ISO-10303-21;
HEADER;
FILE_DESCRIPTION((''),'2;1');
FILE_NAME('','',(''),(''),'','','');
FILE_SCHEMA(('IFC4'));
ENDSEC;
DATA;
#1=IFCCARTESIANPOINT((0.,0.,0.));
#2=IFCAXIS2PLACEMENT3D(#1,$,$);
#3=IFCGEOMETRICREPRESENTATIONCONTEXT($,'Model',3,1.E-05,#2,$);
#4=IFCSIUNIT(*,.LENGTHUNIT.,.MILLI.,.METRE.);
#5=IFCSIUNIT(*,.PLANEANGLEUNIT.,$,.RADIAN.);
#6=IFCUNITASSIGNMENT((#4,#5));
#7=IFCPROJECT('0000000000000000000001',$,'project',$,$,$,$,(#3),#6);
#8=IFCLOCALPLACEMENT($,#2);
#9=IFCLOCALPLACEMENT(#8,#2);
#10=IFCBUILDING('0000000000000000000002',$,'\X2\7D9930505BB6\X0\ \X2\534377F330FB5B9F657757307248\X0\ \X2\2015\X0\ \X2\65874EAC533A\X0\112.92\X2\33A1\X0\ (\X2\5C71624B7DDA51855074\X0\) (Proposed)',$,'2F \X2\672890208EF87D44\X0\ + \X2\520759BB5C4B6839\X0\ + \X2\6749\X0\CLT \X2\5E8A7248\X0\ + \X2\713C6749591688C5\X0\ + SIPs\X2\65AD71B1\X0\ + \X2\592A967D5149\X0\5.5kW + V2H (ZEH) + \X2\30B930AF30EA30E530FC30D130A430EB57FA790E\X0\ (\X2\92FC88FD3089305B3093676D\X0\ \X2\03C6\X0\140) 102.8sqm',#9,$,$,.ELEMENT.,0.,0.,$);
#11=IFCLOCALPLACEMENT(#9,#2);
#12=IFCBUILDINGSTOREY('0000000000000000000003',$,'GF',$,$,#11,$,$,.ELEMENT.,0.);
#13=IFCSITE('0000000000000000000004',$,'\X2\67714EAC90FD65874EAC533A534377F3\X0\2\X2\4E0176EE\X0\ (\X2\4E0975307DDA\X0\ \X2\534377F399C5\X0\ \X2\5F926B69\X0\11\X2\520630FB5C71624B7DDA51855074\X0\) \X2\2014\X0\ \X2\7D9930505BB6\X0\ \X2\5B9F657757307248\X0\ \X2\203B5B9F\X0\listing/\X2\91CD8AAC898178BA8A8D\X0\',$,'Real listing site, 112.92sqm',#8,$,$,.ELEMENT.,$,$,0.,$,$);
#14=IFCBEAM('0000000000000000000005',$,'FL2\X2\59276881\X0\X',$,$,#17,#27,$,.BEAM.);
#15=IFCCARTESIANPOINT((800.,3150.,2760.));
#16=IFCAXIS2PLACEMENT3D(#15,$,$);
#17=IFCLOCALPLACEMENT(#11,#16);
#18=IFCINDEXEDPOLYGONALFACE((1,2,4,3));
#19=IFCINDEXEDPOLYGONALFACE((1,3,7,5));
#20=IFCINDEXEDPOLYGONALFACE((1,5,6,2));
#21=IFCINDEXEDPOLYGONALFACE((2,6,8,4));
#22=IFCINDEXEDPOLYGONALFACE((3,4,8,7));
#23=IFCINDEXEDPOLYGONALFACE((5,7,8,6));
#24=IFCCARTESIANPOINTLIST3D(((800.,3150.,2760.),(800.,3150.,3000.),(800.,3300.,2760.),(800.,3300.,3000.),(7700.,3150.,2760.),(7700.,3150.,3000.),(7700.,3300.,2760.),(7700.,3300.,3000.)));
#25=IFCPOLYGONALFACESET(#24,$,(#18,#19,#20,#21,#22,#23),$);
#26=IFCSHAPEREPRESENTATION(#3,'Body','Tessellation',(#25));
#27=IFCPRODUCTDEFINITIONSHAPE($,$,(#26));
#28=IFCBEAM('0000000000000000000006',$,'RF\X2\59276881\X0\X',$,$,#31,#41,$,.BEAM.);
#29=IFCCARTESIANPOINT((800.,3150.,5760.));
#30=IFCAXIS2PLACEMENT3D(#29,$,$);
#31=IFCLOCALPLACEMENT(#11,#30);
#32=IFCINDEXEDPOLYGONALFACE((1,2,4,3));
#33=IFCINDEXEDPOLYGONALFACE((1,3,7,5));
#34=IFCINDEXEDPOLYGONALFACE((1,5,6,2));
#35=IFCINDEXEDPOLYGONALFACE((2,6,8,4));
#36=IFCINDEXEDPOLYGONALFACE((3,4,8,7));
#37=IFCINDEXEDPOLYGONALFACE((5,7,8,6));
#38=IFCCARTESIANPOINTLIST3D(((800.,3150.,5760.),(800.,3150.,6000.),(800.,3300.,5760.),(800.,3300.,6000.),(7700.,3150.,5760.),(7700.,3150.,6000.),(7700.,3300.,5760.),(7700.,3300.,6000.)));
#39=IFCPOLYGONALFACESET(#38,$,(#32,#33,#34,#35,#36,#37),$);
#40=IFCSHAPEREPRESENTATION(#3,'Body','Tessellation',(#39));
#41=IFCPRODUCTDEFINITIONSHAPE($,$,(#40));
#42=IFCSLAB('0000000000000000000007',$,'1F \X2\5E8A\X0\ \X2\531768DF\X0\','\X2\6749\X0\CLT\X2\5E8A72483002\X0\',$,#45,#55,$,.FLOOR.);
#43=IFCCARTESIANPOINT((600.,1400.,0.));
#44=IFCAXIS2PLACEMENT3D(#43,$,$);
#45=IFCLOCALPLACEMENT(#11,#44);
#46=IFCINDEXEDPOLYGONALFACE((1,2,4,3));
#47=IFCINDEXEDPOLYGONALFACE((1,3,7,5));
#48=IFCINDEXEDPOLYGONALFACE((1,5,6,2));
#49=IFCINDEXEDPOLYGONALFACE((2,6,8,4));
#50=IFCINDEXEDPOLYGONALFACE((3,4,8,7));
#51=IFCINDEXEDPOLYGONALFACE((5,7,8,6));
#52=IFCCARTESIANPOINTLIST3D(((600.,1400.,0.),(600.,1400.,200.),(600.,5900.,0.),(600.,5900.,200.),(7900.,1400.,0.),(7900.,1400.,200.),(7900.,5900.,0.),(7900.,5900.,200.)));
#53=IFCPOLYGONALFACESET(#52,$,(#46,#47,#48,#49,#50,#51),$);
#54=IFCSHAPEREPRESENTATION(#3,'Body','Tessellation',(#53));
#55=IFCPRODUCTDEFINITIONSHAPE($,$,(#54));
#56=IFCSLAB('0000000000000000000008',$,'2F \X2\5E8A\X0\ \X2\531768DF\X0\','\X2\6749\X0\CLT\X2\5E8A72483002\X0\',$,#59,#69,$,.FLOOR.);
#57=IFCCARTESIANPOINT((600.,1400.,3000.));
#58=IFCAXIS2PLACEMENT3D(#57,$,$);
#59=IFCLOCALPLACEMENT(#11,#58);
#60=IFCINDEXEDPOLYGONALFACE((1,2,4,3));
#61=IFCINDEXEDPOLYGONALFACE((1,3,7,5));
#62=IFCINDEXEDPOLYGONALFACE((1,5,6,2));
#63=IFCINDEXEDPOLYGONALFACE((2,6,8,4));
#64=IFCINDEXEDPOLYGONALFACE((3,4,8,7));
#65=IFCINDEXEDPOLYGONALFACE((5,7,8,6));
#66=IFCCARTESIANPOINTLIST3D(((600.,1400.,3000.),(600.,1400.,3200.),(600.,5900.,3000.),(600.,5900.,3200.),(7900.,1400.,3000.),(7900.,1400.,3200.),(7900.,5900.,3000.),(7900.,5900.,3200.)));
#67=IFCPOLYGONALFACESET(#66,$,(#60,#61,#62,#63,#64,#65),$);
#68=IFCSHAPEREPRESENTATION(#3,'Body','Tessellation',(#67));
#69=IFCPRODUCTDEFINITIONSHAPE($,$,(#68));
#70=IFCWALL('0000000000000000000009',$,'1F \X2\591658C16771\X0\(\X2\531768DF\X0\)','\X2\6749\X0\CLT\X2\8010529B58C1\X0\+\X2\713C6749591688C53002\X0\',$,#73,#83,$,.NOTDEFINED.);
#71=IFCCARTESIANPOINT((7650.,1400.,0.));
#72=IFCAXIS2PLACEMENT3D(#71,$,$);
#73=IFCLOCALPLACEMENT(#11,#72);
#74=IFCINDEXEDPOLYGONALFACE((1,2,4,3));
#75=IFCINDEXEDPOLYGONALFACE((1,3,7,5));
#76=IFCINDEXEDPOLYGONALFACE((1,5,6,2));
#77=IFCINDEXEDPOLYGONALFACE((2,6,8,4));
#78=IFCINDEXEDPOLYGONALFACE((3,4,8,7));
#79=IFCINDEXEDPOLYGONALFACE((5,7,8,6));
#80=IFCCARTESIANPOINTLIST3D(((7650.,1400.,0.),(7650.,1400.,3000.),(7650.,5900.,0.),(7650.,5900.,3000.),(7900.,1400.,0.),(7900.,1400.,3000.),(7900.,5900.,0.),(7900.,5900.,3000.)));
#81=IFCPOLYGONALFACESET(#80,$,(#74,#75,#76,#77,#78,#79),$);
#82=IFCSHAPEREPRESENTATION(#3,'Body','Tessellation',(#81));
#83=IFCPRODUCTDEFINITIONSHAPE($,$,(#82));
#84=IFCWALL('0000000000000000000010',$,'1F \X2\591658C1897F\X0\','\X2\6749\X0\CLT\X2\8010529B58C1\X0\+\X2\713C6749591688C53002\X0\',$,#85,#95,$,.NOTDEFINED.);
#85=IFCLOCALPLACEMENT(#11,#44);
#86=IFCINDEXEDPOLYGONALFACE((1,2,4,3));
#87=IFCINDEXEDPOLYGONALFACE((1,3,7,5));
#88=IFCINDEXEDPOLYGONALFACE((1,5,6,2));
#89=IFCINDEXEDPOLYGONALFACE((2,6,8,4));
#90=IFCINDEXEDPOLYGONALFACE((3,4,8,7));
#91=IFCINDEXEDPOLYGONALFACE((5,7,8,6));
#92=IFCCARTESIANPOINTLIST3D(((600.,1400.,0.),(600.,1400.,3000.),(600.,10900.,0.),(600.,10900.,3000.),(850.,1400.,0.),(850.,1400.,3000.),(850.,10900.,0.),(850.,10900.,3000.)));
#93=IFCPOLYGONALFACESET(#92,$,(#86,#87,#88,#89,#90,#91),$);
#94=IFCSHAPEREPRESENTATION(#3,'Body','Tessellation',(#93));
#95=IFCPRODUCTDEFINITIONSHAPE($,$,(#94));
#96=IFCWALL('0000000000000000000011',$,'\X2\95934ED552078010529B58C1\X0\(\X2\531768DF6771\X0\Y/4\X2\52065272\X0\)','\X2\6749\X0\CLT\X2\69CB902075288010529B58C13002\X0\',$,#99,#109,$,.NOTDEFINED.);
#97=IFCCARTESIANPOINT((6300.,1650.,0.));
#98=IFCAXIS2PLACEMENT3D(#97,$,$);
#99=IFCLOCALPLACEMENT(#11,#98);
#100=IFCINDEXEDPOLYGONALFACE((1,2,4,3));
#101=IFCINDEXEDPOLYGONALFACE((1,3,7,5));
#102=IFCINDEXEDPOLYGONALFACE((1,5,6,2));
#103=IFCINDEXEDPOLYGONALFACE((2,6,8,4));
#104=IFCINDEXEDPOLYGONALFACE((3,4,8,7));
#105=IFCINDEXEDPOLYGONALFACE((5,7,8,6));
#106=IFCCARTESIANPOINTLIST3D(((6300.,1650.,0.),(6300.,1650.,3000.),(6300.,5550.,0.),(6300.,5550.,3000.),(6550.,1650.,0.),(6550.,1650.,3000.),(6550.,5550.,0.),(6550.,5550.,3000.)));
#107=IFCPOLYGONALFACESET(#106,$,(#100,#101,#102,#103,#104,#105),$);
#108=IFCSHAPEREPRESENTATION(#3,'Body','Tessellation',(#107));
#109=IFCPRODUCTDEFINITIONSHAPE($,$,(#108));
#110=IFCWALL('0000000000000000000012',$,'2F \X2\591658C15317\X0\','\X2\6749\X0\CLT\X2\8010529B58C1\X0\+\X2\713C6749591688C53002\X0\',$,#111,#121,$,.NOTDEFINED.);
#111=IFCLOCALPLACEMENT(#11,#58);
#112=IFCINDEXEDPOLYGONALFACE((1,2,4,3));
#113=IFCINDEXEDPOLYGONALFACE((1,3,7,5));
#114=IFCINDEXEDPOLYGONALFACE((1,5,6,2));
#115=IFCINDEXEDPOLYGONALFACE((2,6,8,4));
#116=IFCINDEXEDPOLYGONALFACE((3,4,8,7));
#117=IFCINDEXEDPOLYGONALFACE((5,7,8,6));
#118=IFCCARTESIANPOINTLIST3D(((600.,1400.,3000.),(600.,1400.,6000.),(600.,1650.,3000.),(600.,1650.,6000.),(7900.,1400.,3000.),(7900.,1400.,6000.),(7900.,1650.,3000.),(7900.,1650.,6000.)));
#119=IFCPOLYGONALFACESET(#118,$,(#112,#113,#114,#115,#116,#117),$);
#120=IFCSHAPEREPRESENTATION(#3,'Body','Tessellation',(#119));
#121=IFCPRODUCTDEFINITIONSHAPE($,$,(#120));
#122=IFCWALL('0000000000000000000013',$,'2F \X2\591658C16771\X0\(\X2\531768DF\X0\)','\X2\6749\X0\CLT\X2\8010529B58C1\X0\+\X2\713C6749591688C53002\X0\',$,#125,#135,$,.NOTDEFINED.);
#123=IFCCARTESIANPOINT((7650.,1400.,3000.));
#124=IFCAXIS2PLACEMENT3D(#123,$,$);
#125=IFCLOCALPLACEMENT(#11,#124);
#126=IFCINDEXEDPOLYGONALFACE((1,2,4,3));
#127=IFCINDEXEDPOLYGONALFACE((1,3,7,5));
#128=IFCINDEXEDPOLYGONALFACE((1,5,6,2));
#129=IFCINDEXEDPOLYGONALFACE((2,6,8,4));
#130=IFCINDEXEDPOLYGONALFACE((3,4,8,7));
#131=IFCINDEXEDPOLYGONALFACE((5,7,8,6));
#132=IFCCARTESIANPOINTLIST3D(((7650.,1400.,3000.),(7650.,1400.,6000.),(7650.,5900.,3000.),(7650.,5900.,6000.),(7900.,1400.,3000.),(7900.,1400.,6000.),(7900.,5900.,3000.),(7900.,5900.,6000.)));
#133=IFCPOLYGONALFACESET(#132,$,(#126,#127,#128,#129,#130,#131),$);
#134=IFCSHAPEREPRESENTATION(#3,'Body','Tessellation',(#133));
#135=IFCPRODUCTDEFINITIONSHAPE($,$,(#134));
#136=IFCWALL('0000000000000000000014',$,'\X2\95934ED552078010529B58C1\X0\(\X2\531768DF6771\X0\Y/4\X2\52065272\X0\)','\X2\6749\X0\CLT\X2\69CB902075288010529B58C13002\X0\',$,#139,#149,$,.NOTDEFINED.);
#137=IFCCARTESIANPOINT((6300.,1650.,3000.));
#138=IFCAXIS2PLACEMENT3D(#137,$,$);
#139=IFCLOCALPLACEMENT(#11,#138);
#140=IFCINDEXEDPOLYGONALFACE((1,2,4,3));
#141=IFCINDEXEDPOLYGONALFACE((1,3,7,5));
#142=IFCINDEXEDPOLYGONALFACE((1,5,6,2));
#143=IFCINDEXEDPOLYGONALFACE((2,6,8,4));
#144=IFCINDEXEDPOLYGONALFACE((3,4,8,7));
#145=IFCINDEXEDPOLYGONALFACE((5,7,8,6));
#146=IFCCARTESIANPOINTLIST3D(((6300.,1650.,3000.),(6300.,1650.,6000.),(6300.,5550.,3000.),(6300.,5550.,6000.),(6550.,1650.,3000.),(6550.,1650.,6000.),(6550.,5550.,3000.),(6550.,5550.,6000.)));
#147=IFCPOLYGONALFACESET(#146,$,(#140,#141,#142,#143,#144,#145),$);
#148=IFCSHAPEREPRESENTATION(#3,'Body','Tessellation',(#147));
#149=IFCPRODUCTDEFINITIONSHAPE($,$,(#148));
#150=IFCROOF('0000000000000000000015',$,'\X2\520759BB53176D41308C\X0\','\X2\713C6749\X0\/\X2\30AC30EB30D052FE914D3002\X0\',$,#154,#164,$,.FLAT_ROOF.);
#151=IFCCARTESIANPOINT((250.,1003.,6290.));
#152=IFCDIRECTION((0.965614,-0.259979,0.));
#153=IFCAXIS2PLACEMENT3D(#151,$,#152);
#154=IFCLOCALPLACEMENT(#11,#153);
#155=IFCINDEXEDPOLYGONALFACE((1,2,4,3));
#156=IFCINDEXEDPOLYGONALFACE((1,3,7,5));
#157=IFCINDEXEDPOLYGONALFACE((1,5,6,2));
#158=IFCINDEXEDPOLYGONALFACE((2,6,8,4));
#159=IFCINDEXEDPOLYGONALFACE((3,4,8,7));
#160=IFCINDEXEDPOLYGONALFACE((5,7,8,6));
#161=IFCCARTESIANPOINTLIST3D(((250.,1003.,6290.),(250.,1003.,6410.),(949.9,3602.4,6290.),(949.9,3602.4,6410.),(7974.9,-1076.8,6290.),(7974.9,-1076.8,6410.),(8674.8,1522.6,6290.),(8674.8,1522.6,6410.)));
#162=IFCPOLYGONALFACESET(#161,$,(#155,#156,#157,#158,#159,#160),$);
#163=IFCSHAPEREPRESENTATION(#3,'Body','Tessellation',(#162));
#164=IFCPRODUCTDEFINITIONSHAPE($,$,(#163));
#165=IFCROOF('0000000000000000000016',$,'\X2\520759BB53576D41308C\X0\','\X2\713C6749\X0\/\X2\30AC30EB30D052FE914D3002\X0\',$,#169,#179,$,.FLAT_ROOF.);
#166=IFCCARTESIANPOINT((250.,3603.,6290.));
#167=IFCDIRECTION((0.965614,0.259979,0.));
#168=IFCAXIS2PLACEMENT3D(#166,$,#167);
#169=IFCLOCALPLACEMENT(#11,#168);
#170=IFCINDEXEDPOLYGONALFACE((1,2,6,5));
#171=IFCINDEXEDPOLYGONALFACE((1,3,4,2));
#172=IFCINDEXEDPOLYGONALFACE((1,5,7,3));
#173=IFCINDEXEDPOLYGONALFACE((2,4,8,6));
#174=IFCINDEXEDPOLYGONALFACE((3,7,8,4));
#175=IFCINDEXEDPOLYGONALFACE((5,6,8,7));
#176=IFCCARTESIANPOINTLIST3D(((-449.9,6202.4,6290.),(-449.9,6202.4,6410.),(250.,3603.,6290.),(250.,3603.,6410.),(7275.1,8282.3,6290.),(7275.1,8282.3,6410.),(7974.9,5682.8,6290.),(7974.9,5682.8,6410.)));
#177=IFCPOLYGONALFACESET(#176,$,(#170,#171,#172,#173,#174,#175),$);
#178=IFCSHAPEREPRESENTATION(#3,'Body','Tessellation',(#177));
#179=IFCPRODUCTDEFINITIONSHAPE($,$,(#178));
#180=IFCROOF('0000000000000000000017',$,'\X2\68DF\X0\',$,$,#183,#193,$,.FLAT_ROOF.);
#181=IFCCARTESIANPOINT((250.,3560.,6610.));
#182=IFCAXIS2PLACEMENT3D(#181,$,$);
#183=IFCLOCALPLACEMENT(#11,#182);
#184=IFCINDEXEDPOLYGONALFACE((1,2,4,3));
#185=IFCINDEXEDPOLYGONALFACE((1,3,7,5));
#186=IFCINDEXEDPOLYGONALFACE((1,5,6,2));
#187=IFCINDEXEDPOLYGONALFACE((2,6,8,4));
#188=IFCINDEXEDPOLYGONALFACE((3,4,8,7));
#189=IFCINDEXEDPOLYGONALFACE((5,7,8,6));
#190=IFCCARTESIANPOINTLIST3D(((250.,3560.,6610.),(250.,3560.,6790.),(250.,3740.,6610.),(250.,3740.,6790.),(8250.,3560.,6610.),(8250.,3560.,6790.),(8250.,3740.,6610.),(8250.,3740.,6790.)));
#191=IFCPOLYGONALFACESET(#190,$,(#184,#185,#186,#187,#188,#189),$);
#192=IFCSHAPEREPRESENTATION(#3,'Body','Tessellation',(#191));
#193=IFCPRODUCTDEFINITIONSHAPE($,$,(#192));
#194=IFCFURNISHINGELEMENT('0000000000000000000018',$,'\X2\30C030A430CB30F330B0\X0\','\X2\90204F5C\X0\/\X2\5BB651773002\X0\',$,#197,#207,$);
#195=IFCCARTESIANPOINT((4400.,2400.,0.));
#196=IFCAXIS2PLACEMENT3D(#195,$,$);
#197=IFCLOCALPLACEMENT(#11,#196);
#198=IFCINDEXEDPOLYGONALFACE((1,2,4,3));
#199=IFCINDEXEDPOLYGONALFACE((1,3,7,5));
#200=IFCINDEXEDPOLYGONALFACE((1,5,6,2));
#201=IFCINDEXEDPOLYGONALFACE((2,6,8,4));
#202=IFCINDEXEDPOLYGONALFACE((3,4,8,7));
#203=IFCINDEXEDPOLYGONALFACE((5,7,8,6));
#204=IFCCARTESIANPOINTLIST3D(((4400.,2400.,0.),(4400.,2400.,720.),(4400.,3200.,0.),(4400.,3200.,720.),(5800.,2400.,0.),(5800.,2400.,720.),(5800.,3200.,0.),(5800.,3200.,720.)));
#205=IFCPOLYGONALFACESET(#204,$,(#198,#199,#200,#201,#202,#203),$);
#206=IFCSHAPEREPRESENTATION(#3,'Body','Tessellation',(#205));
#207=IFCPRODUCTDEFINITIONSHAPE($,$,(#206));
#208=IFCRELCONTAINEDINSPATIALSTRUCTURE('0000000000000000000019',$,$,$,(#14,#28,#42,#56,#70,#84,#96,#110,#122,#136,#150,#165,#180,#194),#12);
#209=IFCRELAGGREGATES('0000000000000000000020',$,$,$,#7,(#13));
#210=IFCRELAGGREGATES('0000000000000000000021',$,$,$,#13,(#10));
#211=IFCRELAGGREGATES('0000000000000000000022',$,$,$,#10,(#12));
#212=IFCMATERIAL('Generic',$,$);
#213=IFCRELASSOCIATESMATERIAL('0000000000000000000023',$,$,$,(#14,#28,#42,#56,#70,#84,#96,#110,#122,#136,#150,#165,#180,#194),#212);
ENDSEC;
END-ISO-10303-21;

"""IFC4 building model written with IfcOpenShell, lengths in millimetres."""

from ifc_helpers import new_model, si_unit, frame, frame_2d, origin, place, context, project, spatial, rectangle, extrude, material, element, save


model = new_model("IFC4")

# Units and contexts
model_context = context("Model", 3, precision=1e-05, world=origin())
ifc_project = project(units=[si_unit("LENGTHUNIT", "METRE", prefix="MILLI"), si_unit("PLANEANGLEUNIT", "RADIAN")], contexts=[model_context])

# Site, building, storey
site_placement = place(None, origin())
site = spatial("IfcSite", under=ifc_project, at=site_placement, Name="東京都文京区千石2丁目 (三田線 千石駅 徒歩11分・山手線内側) — 継ぐ家 実敷地版 ※実listing/重説要確認", ObjectType="Real listing site, 112.92sqm", CompositionType="ELEMENT", RefElevation=0.0)
building_placement = place(site_placement, origin())
building = spatial("IfcBuilding", under=site, at=building_placement, Name="継ぐ家 千石・実敷地版 ― 文京区112.92㎡ (山手線内側) (Proposed)", ObjectType="2F 木造軸組 + 切妻屋根 + 杉CLT 床版 + 焼杉外装 + SIPs断熱 + 太陽光5.5kW + V2H (ZEH) + スクリューパイル基礎 (鋼製らせん杭 φ140) 102.8sqm", CompositionType="ELEMENT", ElevationOfRefHeight=0.0, ElevationOfTerrain=0.0)
storey_placement = place(building_placement, origin())
storey = spatial("IfcBuildingStorey", under=building, at=storey_placement, Name="GF", CompositionType="ELEMENT", Elevation=0.0)

# Shared definitions
ifc_material = material(Name="Generic")

# Beams
beam_1_placement = place(storey_placement, frame((800.0, 3150.0, 2760.0)))
element("IfcBeam", 1, at=beam_1_placement, inside=storey, material=ifc_material, Name="FL2大梁X", PredefinedType="BEAM", context=model_context, shape_type="SweptSolid", body=[
    extrude(rectangle(XDim=6900.0, YDim=150.0, at=frame_2d((3450.0, 75.0))), frame((800.0, 3150.0, 2760.0)), (0.0, 0.0, 1.0), 240.0),
])
beam_2_placement = place(storey_placement, frame((800.0, 3150.0, 5760.0)))
element("IfcBeam", 2, at=beam_2_placement, inside=storey, material=ifc_material, Name="RF大梁X", PredefinedType="BEAM", context=model_context, shape_type="SweptSolid", body=[
    extrude(rectangle(XDim=6900.0, YDim=150.0, at=frame_2d((3450.0, 75.0))), frame((800.0, 3150.0, 5760.0)), (0.0, 0.0, 1.0), 240.0),
])

# Slabs
slab_1_placement = place(storey_placement, frame((600.0, 1400.0, 0.0)))
element("IfcSlab", 3, at=slab_1_placement, inside=storey, material=ifc_material, Name="1F 床 北棟", Description="杉CLT床版。", PredefinedType="FLOOR", context=model_context, shape_type="SweptSolid", body=[
    extrude(rectangle(XDim=7300.0, YDim=4500.0, at=frame_2d((3650.0, 2250.0))), frame((600.0, 1400.0, 0.0)), (0.0, 0.0, 1.0), 200.0),
])
slab_2_placement = place(storey_placement, frame((600.0, 1400.0, 3000.0)))
element("IfcSlab", 4, at=slab_2_placement, inside=storey, material=ifc_material, Name="2F 床 北棟", Description="杉CLT床版。", PredefinedType="FLOOR", context=model_context, shape_type="SweptSolid", body=[
    extrude(rectangle(XDim=7300.0, YDim=4500.0, at=frame_2d((3650.0, 2250.0))), frame((600.0, 1400.0, 3000.0)), (0.0, 0.0, 1.0), 200.0),
])

# Walls
wall_1_placement = place(storey_placement, frame((7650.0, 1400.0, 0.0)))
element("IfcWall", 5, at=wall_1_placement, inside=storey, material=ifc_material, Name="1F 外壁東(北棟)", Description="杉CLT耐力壁+焼杉外装。", PredefinedType="NOTDEFINED", context=model_context, shape_type="SweptSolid", body=[
    extrude(rectangle(XDim=250.0, YDim=4500.0, at=frame_2d((125.0, 2250.0))), frame((7650.0, 1400.0, 0.0)), (0.0, 0.0, 1.0), 3000.0),
])
wall_2_placement = place(storey_placement, frame((600.0, 1400.0, 0.0)))
element("IfcWall", 6, at=wall_2_placement, inside=storey, material=ifc_material, Name="1F 外壁西", Description="杉CLT耐力壁+焼杉外装。", PredefinedType="NOTDEFINED", context=model_context, shape_type="SweptSolid", body=[
    extrude(rectangle(XDim=250.0, YDim=9500.0, at=frame_2d((125.0, 4750.0))), frame((600.0, 1400.0, 0.0)), (0.0, 0.0, 1.0), 3000.0),
])
wall_3_placement = place(storey_placement, frame((6300.0, 1650.0, 0.0)))
element("IfcWall", 7, at=wall_3_placement, inside=storey, material=ifc_material, Name="間仕切耐力壁(北棟東Y/4分割)", Description="杉CLT構造用耐力壁。", PredefinedType="NOTDEFINED", context=model_context, shape_type="SweptSolid", body=[
    extrude(rectangle(XDim=250.0, YDim=3900.0, at=frame_2d((125.0, 1950.0))), frame((6300.0, 1650.0, 0.0)), (0.0, 0.0, 1.0), 3000.0),
])
wall_4_placement = place(storey_placement, frame((600.0, 1400.0, 3000.0)))
element("IfcWall", 8, at=wall_4_placement, inside=storey, material=ifc_material, Name="2F 外壁北", Description="杉CLT耐力壁+焼杉外装。", PredefinedType="NOTDEFINED", context=model_context, shape_type="SweptSolid", body=[
    extrude(rectangle(XDim=7300.0, YDim=250.0, at=frame_2d((3650.0, 125.0))), frame((600.0, 1400.0, 3000.0)), (0.0, 0.0, 1.0), 3000.0),
])
wall_5_placement = place(storey_placement, frame((7650.0, 1400.0, 3000.0)))
element("IfcWall", 9, at=wall_5_placement, inside=storey, material=ifc_material, Name="2F 外壁東(北棟)", Description="杉CLT耐力壁+焼杉外装。", PredefinedType="NOTDEFINED", context=model_context, shape_type="SweptSolid", body=[
    extrude(rectangle(XDim=250.0, YDim=4500.0, at=frame_2d((125.0, 2250.0))), frame((7650.0, 1400.0, 3000.0)), (0.0, 0.0, 1.0), 3000.0),
])

# Wall
wall_6_placement = place(storey_placement, frame((6300.0, 1650.0, 3000.0)))
element("IfcWall", 10, at=wall_6_placement, inside=storey, material=ifc_material, Name="間仕切耐力壁(北棟東Y/4分割)", Description="杉CLT構造用耐力壁。", PredefinedType="NOTDEFINED", context=model_context, shape_type="SweptSolid", body=[
    extrude(rectangle(XDim=250.0, YDim=3900.0, at=frame_2d((125.0, 1950.0))), frame((6300.0, 1650.0, 3000.0)), (0.0, 0.0, 1.0), 3000.0),
])

# Roofs
roof_1_placement = place(storey_placement, frame((250.0, 1003.0, 6290.0), x_axis=(0.965614, -0.259979, 0.0)))
element("IfcRoof", 11, at=roof_1_placement, inside=storey, material=ifc_material, Name="切妻北流れ", Description="焼杉/ガルバ勾配。", PredefinedType="FLAT_ROOF", context=model_context, shape_type="SweptSolid", body=[
    extrude(rectangle(XDim=8000.0, YDim=2692.0, at=frame_2d((4000.0, 1346.0))), frame((250.0, 1003.0, 6290.0), x_axis=(0.965614, -0.259979, 0.0)), (0.0, 0.0, 1.0), 120.0),
])
roof_2_placement = place(storey_placement, frame((250.0, 3603.0, 6290.0), x_axis=(0.965614, 0.259979, 0.0)))
element("IfcRoof", 12, at=roof_2_placement, inside=storey, material=ifc_material, Name="切妻南流れ", Description="焼杉/ガルバ勾配。", PredefinedType="FLAT_ROOF", context=model_context, shape_type="SweptSolid", body=[
    extrude(rectangle(XDim=8000.0, YDim=2692.0, at=frame_2d((4000.0, 1346.0))), frame((250.0, 3603.0, 6290.0), x_axis=(0.965614, 0.259979, 0.0)), (0.0, 0.0, 1.0), 120.0),
])
roof_3_placement = place(storey_placement, frame((250.0, 3560.0, 6610.0)))
element("IfcRoof", 13, at=roof_3_placement, inside=storey, material=ifc_material, Name="棟", PredefinedType="FLAT_ROOF", context=model_context, shape_type="SweptSolid", body=[
    extrude(rectangle(XDim=8000.0, YDim=180.0, at=frame_2d((4000.0, 90.0))), frame((250.0, 3560.0, 6610.0)), (0.0, 0.0, 1.0), 180.0),
])

# Furnishing element
furnishing_1_placement = place(storey_placement, frame((4400.0, 2400.0, 0.0)))
element("IfcFurnishingElement", 14, at=furnishing_1_placement, inside=storey, material=ifc_material, Name="ダイニング", Description="造作/家具。", context=model_context, shape_type="SweptSolid", body=[
    extrude(rectangle(XDim=1400.0, YDim=800.0, at=frame_2d((700.0, 400.0))), frame((4400.0, 2400.0, 0.0)), (0.0, 0.0, 1.0), 720.0),
])

save(model, "model.ifc")
